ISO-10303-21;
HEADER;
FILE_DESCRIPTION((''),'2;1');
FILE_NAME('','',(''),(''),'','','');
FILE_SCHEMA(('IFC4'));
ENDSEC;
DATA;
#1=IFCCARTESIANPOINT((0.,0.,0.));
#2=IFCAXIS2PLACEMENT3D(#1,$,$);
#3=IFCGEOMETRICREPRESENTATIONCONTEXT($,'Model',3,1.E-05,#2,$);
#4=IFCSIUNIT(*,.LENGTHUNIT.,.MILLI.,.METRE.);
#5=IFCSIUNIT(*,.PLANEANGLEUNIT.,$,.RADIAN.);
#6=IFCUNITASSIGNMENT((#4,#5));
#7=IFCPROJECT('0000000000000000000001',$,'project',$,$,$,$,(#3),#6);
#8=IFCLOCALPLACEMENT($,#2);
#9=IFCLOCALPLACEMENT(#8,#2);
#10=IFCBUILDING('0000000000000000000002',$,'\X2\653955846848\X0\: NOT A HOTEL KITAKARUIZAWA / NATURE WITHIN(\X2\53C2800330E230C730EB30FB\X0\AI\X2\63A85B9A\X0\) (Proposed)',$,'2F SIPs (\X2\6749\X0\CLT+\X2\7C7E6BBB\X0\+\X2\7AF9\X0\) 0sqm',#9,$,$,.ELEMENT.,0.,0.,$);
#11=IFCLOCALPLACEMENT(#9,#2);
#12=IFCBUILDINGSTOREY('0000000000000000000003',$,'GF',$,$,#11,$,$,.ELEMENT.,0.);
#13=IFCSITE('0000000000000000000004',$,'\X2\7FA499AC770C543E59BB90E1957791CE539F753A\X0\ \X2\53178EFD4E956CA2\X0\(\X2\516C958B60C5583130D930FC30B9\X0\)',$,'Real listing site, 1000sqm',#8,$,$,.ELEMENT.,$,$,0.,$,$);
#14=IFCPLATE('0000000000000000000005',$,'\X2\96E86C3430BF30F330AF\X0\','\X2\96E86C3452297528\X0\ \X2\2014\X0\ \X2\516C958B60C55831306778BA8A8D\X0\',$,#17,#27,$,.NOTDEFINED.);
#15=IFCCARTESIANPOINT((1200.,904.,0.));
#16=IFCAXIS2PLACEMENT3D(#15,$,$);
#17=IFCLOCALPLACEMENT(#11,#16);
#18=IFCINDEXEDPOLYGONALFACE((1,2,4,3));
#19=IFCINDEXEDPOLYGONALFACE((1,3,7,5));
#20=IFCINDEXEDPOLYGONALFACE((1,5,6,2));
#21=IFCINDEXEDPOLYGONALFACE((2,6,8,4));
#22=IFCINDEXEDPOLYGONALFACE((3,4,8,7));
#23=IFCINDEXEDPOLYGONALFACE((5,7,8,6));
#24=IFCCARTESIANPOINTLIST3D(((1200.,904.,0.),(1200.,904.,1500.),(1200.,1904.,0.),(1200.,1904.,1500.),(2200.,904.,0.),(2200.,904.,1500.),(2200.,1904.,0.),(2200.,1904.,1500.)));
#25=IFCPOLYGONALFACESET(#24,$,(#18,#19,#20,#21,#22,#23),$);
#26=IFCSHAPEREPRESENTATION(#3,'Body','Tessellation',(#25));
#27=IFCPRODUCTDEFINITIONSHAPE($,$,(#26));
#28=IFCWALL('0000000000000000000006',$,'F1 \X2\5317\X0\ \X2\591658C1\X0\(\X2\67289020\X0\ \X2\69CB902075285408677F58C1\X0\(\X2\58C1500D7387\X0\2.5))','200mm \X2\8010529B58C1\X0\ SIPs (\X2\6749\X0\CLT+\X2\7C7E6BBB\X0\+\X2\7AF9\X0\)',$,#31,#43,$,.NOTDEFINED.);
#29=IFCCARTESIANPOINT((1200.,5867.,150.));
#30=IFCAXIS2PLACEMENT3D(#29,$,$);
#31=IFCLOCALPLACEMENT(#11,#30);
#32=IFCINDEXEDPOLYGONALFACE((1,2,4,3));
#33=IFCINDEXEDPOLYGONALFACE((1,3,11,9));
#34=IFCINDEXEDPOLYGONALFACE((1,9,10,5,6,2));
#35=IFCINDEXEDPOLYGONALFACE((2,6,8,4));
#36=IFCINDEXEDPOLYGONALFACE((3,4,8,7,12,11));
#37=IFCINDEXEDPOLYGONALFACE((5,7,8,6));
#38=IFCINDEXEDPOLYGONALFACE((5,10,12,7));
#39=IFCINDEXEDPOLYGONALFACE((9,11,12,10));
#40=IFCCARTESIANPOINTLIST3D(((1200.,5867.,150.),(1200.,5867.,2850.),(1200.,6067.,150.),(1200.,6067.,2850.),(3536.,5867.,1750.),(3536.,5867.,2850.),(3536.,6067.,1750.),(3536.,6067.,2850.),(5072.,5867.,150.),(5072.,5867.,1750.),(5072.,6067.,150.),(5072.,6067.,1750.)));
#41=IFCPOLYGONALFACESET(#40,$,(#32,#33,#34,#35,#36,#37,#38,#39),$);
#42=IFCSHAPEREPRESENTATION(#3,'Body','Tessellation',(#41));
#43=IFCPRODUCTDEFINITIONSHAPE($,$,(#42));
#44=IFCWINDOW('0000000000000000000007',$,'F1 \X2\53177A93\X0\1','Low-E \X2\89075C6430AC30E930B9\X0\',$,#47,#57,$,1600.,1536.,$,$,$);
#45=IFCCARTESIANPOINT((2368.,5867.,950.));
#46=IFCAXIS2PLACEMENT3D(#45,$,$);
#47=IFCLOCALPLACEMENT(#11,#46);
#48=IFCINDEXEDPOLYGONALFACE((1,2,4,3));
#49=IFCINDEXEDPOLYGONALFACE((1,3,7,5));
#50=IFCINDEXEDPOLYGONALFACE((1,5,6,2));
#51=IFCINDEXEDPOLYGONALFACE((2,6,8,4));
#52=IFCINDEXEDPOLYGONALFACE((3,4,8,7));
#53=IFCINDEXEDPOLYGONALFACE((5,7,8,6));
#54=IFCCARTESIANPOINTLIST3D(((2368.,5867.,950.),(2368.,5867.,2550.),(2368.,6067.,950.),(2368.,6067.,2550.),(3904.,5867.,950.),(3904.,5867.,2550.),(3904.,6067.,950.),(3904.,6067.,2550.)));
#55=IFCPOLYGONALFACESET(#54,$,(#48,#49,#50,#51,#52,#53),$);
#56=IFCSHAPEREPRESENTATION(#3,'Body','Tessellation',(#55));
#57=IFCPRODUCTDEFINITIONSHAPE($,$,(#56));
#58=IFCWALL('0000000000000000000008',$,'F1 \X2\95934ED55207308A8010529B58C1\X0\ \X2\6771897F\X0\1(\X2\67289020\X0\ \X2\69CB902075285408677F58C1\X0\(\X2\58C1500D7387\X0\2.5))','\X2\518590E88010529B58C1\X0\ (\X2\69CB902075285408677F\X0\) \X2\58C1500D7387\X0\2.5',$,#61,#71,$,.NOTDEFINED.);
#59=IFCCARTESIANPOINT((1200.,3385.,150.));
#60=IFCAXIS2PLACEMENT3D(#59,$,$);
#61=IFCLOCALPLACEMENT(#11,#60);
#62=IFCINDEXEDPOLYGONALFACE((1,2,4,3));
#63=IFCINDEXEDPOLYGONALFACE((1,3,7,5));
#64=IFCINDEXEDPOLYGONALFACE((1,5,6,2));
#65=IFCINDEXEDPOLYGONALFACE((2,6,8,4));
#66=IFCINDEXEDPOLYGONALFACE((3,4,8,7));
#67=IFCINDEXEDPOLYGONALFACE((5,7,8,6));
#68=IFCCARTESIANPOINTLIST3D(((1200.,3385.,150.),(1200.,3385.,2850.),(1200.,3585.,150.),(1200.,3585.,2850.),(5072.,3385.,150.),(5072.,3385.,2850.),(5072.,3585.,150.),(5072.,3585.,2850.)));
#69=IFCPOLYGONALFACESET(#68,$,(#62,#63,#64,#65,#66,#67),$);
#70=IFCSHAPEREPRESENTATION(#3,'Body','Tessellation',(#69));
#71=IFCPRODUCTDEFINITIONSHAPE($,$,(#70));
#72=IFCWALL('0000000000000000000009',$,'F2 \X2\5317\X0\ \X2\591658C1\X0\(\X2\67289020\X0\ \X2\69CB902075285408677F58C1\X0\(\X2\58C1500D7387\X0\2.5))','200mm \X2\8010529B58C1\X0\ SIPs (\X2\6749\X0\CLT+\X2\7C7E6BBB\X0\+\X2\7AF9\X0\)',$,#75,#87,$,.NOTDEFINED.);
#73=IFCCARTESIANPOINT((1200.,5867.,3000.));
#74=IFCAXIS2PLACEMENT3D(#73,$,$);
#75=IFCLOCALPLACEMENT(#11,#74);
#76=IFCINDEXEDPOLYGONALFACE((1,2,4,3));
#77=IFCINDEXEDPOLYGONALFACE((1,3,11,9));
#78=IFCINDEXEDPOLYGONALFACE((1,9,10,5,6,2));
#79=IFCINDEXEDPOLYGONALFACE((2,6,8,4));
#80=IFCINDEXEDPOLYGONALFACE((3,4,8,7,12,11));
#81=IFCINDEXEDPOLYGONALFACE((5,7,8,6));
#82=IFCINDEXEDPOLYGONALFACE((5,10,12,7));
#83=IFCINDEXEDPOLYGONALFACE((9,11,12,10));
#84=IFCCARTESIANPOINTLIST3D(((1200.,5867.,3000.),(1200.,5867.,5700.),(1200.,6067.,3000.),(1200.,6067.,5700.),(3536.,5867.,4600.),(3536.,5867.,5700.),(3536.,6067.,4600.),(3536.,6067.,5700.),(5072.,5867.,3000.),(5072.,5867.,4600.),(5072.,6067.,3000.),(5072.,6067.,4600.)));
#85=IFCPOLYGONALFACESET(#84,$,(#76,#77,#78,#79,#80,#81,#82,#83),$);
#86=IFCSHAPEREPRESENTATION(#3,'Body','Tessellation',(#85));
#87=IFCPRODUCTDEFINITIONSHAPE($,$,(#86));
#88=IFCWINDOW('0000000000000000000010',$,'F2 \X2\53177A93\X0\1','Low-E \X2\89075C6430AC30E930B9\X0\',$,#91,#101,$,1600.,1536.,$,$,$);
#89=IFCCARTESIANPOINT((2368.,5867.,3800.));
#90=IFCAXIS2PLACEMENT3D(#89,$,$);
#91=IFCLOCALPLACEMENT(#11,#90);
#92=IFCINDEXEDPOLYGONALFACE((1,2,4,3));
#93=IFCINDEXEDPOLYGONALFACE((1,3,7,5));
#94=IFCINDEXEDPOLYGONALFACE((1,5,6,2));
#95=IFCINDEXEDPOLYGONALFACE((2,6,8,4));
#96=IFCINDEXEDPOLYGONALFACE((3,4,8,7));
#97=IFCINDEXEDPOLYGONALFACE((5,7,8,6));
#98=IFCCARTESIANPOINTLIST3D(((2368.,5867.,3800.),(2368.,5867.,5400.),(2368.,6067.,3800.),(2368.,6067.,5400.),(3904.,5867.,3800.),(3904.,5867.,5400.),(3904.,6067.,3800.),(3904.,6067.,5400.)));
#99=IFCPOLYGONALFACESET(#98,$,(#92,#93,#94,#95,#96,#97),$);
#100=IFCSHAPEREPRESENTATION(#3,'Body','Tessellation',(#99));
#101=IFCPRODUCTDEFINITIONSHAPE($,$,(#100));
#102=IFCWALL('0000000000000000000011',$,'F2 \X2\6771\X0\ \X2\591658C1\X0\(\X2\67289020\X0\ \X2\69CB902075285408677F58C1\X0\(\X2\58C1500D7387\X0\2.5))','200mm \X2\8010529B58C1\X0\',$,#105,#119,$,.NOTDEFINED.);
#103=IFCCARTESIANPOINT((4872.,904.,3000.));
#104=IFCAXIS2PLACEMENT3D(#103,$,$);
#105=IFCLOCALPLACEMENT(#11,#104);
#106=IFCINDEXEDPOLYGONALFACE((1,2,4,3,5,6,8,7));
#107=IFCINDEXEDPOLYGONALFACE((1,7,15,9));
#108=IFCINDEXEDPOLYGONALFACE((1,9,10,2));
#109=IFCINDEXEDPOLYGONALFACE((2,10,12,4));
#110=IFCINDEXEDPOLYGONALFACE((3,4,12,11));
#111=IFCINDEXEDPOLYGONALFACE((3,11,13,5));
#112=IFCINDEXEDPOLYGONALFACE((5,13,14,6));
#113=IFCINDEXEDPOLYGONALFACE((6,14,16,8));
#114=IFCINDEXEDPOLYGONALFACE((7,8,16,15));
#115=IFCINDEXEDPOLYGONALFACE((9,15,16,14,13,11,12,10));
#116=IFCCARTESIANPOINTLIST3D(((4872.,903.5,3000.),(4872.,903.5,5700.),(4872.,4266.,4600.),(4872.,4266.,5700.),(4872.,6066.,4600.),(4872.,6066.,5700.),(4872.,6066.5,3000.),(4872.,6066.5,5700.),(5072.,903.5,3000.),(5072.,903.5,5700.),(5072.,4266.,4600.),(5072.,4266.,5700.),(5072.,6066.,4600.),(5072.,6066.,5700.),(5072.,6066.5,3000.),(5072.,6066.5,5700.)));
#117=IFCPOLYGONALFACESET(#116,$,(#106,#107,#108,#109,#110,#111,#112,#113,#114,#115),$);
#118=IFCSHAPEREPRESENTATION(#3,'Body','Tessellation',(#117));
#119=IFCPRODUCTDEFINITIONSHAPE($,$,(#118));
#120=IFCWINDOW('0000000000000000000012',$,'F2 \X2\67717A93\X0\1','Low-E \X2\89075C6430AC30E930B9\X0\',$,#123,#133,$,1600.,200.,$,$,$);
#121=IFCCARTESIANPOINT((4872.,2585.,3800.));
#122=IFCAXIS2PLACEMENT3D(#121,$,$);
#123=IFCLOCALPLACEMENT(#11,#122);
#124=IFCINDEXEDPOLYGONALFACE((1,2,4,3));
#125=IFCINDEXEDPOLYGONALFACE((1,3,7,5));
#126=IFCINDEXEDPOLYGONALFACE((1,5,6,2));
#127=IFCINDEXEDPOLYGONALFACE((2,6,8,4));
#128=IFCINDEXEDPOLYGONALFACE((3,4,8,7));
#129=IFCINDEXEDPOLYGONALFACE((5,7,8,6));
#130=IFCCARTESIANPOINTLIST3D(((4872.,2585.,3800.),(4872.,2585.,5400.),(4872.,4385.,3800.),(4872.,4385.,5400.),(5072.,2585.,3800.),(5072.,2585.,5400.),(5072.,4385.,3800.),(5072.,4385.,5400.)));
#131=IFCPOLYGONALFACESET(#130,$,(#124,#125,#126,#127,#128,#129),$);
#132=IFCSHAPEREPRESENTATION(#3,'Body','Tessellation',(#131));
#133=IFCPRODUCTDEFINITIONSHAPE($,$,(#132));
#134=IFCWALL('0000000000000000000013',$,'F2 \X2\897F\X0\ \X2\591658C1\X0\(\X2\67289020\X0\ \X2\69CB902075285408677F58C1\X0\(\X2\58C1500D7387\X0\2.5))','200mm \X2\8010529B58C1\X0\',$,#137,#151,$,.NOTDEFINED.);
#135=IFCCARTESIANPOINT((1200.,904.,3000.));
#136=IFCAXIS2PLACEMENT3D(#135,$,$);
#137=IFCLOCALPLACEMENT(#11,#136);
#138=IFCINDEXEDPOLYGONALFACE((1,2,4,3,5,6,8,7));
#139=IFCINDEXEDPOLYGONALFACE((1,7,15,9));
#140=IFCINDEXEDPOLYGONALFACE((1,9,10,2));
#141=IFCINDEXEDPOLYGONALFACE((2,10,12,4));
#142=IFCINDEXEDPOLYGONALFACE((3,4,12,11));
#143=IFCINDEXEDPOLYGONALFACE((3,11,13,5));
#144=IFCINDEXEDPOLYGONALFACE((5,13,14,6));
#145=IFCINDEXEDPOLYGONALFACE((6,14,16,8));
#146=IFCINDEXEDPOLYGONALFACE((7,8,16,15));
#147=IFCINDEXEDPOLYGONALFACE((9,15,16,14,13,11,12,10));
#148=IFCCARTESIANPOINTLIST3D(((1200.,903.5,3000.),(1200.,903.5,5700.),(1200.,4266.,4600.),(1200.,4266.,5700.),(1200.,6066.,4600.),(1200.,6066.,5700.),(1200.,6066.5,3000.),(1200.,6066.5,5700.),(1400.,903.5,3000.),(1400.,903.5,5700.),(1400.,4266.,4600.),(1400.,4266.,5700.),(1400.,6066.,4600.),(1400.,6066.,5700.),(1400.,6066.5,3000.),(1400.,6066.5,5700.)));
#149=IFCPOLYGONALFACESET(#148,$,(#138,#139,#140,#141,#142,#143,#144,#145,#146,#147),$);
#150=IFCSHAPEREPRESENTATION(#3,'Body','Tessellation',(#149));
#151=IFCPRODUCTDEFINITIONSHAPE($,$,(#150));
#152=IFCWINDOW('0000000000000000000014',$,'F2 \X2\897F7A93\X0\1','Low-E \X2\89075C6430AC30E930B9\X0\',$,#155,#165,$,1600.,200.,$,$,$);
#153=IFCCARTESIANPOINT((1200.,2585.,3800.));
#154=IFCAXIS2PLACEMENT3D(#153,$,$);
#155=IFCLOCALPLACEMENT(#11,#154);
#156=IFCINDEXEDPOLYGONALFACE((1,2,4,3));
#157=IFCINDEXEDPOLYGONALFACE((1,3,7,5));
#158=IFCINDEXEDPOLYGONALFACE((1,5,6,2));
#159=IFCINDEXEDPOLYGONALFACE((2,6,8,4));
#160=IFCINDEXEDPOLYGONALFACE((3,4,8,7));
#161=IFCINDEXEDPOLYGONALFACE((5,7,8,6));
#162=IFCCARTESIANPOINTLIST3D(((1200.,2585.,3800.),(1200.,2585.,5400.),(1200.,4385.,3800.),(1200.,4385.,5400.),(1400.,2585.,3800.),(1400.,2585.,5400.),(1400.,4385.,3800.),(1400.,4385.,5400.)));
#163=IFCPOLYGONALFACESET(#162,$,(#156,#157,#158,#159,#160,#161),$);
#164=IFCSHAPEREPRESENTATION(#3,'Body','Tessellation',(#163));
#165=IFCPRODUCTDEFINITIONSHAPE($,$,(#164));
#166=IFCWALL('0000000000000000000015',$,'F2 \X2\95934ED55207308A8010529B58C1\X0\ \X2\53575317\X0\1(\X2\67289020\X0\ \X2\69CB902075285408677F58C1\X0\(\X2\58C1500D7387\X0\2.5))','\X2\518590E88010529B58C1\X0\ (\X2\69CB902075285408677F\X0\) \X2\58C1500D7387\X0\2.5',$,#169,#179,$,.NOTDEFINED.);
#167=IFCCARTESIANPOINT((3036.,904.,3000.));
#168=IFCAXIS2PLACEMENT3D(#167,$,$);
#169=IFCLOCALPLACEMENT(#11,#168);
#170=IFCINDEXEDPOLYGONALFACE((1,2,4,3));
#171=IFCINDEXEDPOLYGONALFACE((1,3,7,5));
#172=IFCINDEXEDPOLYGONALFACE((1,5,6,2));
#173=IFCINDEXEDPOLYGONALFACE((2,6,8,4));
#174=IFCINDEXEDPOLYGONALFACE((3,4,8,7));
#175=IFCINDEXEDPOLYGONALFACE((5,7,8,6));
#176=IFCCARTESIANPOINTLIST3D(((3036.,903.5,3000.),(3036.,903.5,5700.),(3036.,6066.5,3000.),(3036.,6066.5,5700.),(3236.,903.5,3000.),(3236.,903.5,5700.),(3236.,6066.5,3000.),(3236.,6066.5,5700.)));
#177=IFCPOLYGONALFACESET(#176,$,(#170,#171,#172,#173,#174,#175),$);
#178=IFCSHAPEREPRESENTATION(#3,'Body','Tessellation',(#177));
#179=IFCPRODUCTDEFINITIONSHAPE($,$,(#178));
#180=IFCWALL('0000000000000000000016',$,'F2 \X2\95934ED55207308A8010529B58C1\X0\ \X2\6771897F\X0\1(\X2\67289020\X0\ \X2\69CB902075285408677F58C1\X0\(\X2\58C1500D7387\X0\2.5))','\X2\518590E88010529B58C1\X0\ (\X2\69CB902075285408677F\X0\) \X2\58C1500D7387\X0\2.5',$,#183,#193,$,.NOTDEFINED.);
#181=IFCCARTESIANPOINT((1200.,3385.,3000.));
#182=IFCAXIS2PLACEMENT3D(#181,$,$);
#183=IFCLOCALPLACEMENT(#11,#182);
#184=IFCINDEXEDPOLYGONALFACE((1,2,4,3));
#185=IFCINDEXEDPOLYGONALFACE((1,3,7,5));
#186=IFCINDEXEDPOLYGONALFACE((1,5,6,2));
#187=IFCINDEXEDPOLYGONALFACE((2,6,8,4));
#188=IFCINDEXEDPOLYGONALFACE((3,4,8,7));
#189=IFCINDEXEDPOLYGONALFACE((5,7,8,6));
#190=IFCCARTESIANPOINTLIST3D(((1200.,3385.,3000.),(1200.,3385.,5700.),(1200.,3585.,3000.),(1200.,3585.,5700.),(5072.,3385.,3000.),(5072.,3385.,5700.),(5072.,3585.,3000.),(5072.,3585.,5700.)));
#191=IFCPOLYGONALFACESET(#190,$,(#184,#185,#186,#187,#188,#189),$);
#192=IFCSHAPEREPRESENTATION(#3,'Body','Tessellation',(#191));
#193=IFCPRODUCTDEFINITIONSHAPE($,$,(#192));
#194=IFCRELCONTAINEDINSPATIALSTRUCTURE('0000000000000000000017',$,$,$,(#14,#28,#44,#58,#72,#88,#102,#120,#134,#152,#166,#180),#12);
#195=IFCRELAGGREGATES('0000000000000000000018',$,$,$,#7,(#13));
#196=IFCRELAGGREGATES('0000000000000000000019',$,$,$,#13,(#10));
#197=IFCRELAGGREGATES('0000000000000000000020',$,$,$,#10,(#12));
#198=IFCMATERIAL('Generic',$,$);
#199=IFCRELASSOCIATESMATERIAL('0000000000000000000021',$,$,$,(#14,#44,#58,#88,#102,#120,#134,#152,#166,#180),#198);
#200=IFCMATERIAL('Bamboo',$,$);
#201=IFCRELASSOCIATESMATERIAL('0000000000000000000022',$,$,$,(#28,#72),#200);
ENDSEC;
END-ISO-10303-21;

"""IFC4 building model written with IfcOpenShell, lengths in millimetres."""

from ifc_helpers import new_model, si_unit, frame, frame_2d, origin, place, context, project, spatial, rectangle, extrude, material, element, fill, save


model = new_model("IFC4")

# Units and contexts
model_context = context("Model", 3, precision=1e-05, world=origin())
ifc_project = project(units=[si_unit("LENGTHUNIT", "METRE", prefix="MILLI"), si_unit("PLANEANGLEUNIT", "RADIAN")], contexts=[model_context])

# Site, building, storey
site_placement = place(None, origin())
site = spatial("IfcSite", under=ifc_project, at=site_placement, Name="群馬県吾妻郡長野原町 北軽井沢(公開情報ベース)", ObjectType="Real listing site, 1000sqm", CompositionType="ELEMENT", RefElevation=0.0)
building_placement = place(site_placement, origin())
building = spatial("IfcBuilding", under=site, at=building_placement, Name="改善案: NOT A HOTEL KITAKARUIZAWA / NATURE WITHIN(参考モデル・AI推定) (Proposed)", ObjectType="2F SIPs (杉CLT+籾殻+竹) 0sqm", CompositionType="ELEMENT", ElevationOfRefHeight=0.0, ElevationOfTerrain=0.0)
storey_placement = place(building_placement, origin())
storey = spatial("IfcBuildingStorey", under=building, at=storey_placement, Name="GF", CompositionType="ELEMENT", Elevation=0.0)

# Plate
ifc_material_1 = material(Name="Generic")
plate_placement = place(storey_placement, frame((1200.0, 904.0, 0.0)))
element("IfcPlate", 1, at=plate_placement, inside=storey, material=ifc_material_1, Name="雨水タンク", Description="雨水利用 — 公開情報で確認", PredefinedType="NOTDEFINED", context=model_context, shape_type="SweptSolid", body=[
    extrude(rectangle(XDim=1000.0, YDim=1000.0, at=frame_2d((500.0, 500.0))), frame((1200.0, 904.0, 0.0)), (0.0, 0.0, 1.0), 1500.0),
])

# Wall, opening, window
ifc_material_2 = material(Name="Bamboo")
wall_1_placement = place(storey_placement, frame((1200.0, 5867.0, 150.0)))
wall_1 = element("IfcWall", 2, at=wall_1_placement, inside=storey, material=ifc_material_2, Name="F1 北 外壁(木造 構造用合板壁(壁倍率2.5))", Description="200mm 耐力壁 SIPs (杉CLT+籾殻+竹)", PredefinedType="NOTDEFINED", context=model_context, shape_type="SweptSolid", body=[
    extrude(rectangle(XDim=3872.0, YDim=200.0, at=frame_2d((1936.0, 100.0))), frame((1200.0, 5867.0, 150.0)), (0.0, 0.0, 1.0), 2700.0),
])
opening_1_placement = place(storey_placement, frame((2368.0, 5867.0, 950.0)))
opening_1 = element("IfcOpeningElement", 3, at=opening_1_placement, cuts=wall_1, PredefinedType="NOTDEFINED", context=model_context, shape_type="SweptSolid", body=[
    extrude(rectangle(XDim=1536.0, YDim=200.0, at=frame_2d((768.0, 100.0))), frame((2368.0, 5867.0, 950.0)), (0.0, 0.0, 1.0), 1600.0),
])
window_1_placement = place(storey_placement, frame((2368.0, 5867.0, 950.0)))
window_1 = element("IfcWindow", 4, at=window_1_placement, inside=storey, material=ifc_material_1, Name="F1 北窓1", Description="Low-E 複層ガラス", OverallHeight=1600.0, OverallWidth=1536.0, context=model_context, shape_type="SweptSolid", body=[
    extrude(rectangle(XDim=1536.0, YDim=200.0, at=frame_2d((768.0, 100.0))), frame((2368.0, 5867.0, 950.0)), (0.0, 0.0, 1.0), 1600.0),
])
fill(opening_1, window_1)

# Wall
wall_2_placement = place(storey_placement, frame((1200.0, 3385.0, 150.0)))
element("IfcWall", 5, at=wall_2_placement, inside=storey, material=ifc_material_1, Name="F1 間仕切り耐力壁 東西1(木造 構造用合板壁(壁倍率2.5))", Description="内部耐力壁 (構造用合板) 壁倍率2.5", PredefinedType="NOTDEFINED", context=model_context, shape_type="SweptSolid", body=[
    extrude(rectangle(XDim=3872.0, YDim=200.0, at=frame_2d((1936.0, 100.0))), frame((1200.0, 3385.0, 150.0)), (0.0, 0.0, 1.0), 2700.0),
])

# Walls, openings, windows
wall_3_placement = place(storey_placement, frame((1200.0, 5867.0, 3000.0)))
wall_3 = element("IfcWall", 6, at=wall_3_placement, inside=storey, material=ifc_material_2, Name="F2 北 外壁(木造 構造用合板壁(壁倍率2.5))", Description="200mm 耐力壁 SIPs (杉CLT+籾殻+竹)", PredefinedType="NOTDEFINED", context=model_context, shape_type="SweptSolid", body=[
    extrude(rectangle(XDim=3872.0, YDim=200.0, at=frame_2d((1936.0, 100.0))), frame((1200.0, 5867.0, 3000.0)), (0.0, 0.0, 1.0), 2700.0),
])
opening_2_placement = place(storey_placement, frame((2368.0, 5867.0, 3800.0)))
opening_2 = element("IfcOpeningElement", 7, at=opening_2_placement, cuts=wall_3, PredefinedType="NOTDEFINED", context=model_context, shape_type="SweptSolid", body=[
    extrude(rectangle(XDim=1536.0, YDim=200.0, at=frame_2d((768.0, 100.0))), frame((2368.0, 5867.0, 3800.0)), (0.0, 0.0, 1.0), 1600.0),
])
window_2_placement = place(storey_placement, frame((2368.0, 5867.0, 3800.0)))
window_2 = element("IfcWindow", 8, at=window_2_placement, inside=storey, material=ifc_material_1, Name="F2 北窓1", Description="Low-E 複層ガラス", OverallHeight=1600.0, OverallWidth=1536.0, context=model_context, shape_type="SweptSolid", body=[
    extrude(rectangle(XDim=1536.0, YDim=200.0, at=frame_2d((768.0, 100.0))), frame((2368.0, 5867.0, 3800.0)), (0.0, 0.0, 1.0), 1600.0),
])
fill(opening_2, window_2)
wall_4_placement = place(storey_placement, frame((4872.0, 904.0, 3000.0)))
wall_4 = element("IfcWall", 9, at=wall_4_placement, inside=storey, material=ifc_material_1, Name="F2 東 外壁(木造 構造用合板壁(壁倍率2.5))", Description="200mm 耐力壁", PredefinedType="NOTDEFINED", context=model_context, shape_type="SweptSolid", body=[
    extrude(rectangle(XDim=200.0, YDim=5163.0, at=frame_2d((100.0, 2581.0))), frame((4872.0, 904.0, 3000.0)), (0.0, 0.0, 1.0), 2700.0),
])
opening_3_placement = place(storey_placement, frame((4872.0, 2585.0, 3800.0)))
opening_3 = element("IfcOpeningElement", 10, at=opening_3_placement, cuts=wall_4, PredefinedType="NOTDEFINED", context=model_context, shape_type="SweptSolid", body=[
    extrude(rectangle(XDim=200.0, YDim=1800.0, at=frame_2d((100.0, 900.0))), frame((4872.0, 2585.0, 3800.0)), (0.0, 0.0, 1.0), 1600.0),
])
window_3_placement = place(storey_placement, frame((4872.0, 2585.0, 3800.0)))
window_3 = element("IfcWindow", 11, at=window_3_placement, inside=storey, material=ifc_material_1, Name="F2 東窓1", Description="Low-E 複層ガラス", OverallHeight=1600.0, OverallWidth=200.0, context=model_context, shape_type="SweptSolid", body=[
    extrude(rectangle(XDim=200.0, YDim=1800.0, at=frame_2d((100.0, 900.0))), frame((4872.0, 2585.0, 3800.0)), (0.0, 0.0, 1.0), 1600.0),
])
fill(opening_3, window_3)
wall_5_placement = place(storey_placement, frame((1200.0, 904.0, 3000.0)))
wall_5 = element("IfcWall", 12, at=wall_5_placement, inside=storey, material=ifc_material_1, Name="F2 西 外壁(木造 構造用合板壁(壁倍率2.5))", Description="200mm 耐力壁", PredefinedType="NOTDEFINED", context=model_context, shape_type="SweptSolid", body=[
    extrude(rectangle(XDim=200.0, YDim=5163.0, at=frame_2d((100.0, 2581.0))), frame((1200.0, 904.0, 3000.0)), (0.0, 0.0, 1.0), 2700.0),
])
opening_4_placement = place(storey_placement, frame((1200.0, 2585.0, 3800.0)))
opening_4 = element("IfcOpeningElement", 13, at=opening_4_placement, cuts=wall_5, PredefinedType="NOTDEFINED", context=model_context, shape_type="SweptSolid", body=[
    extrude(rectangle(XDim=200.0, YDim=1800.0, at=frame_2d((100.0, 900.0))), frame((1200.0, 2585.0, 3800.0)), (0.0, 0.0, 1.0), 1600.0),
])
window_4_placement = place(storey_placement, frame((1200.0, 2585.0, 3800.0)))
window_4 = element("IfcWindow", 14, at=window_4_placement, inside=storey, material=ifc_material_1, Name="F2 西窓1", Description="Low-E 複層ガラス", OverallHeight=1600.0, OverallWidth=200.0, context=model_context, shape_type="SweptSolid", body=[
    extrude(rectangle(XDim=200.0, YDim=1800.0, at=frame_2d((100.0, 900.0))), frame((1200.0, 2585.0, 3800.0)), (0.0, 0.0, 1.0), 1600.0),
])
fill(opening_4, window_4)

# Walls
wall_6_placement = place(storey_placement, frame((3036.0, 904.0, 3000.0)))
element("IfcWall", 15, at=wall_6_placement, inside=storey, material=ifc_material_1, Name="F2 間仕切り耐力壁 南北1(木造 構造用合板壁(壁倍率2.5))", Description="内部耐力壁 (構造用合板) 壁倍率2.5", PredefinedType="NOTDEFINED", context=model_context, shape_type="SweptSolid", body=[
    extrude(rectangle(XDim=200.0, YDim=5163.0, at=frame_2d((100.0, 2581.0))), frame((3036.0, 904.0, 3000.0)), (0.0, 0.0, 1.0), 2700.0),
])
wall_7_placement = place(storey_placement, frame((1200.0, 3385.0, 3000.0)))
element("IfcWall", 16, at=wall_7_placement, inside=storey, material=ifc_material_1, Name="F2 間仕切り耐力壁 東西1(木造 構造用合板壁(壁倍率2.5))", Description="内部耐力壁 (構造用合板) 壁倍率2.5", PredefinedType="NOTDEFINED", context=model_context, shape_type="SweptSolid", body=[
    extrude(rectangle(XDim=3872.0, YDim=200.0, at=frame_2d((1936.0, 100.0))), frame((1200.0, 3385.0, 3000.0)), (0.0, 0.0, 1.0), 2700.0),
])

save(model, "model.ifc")
